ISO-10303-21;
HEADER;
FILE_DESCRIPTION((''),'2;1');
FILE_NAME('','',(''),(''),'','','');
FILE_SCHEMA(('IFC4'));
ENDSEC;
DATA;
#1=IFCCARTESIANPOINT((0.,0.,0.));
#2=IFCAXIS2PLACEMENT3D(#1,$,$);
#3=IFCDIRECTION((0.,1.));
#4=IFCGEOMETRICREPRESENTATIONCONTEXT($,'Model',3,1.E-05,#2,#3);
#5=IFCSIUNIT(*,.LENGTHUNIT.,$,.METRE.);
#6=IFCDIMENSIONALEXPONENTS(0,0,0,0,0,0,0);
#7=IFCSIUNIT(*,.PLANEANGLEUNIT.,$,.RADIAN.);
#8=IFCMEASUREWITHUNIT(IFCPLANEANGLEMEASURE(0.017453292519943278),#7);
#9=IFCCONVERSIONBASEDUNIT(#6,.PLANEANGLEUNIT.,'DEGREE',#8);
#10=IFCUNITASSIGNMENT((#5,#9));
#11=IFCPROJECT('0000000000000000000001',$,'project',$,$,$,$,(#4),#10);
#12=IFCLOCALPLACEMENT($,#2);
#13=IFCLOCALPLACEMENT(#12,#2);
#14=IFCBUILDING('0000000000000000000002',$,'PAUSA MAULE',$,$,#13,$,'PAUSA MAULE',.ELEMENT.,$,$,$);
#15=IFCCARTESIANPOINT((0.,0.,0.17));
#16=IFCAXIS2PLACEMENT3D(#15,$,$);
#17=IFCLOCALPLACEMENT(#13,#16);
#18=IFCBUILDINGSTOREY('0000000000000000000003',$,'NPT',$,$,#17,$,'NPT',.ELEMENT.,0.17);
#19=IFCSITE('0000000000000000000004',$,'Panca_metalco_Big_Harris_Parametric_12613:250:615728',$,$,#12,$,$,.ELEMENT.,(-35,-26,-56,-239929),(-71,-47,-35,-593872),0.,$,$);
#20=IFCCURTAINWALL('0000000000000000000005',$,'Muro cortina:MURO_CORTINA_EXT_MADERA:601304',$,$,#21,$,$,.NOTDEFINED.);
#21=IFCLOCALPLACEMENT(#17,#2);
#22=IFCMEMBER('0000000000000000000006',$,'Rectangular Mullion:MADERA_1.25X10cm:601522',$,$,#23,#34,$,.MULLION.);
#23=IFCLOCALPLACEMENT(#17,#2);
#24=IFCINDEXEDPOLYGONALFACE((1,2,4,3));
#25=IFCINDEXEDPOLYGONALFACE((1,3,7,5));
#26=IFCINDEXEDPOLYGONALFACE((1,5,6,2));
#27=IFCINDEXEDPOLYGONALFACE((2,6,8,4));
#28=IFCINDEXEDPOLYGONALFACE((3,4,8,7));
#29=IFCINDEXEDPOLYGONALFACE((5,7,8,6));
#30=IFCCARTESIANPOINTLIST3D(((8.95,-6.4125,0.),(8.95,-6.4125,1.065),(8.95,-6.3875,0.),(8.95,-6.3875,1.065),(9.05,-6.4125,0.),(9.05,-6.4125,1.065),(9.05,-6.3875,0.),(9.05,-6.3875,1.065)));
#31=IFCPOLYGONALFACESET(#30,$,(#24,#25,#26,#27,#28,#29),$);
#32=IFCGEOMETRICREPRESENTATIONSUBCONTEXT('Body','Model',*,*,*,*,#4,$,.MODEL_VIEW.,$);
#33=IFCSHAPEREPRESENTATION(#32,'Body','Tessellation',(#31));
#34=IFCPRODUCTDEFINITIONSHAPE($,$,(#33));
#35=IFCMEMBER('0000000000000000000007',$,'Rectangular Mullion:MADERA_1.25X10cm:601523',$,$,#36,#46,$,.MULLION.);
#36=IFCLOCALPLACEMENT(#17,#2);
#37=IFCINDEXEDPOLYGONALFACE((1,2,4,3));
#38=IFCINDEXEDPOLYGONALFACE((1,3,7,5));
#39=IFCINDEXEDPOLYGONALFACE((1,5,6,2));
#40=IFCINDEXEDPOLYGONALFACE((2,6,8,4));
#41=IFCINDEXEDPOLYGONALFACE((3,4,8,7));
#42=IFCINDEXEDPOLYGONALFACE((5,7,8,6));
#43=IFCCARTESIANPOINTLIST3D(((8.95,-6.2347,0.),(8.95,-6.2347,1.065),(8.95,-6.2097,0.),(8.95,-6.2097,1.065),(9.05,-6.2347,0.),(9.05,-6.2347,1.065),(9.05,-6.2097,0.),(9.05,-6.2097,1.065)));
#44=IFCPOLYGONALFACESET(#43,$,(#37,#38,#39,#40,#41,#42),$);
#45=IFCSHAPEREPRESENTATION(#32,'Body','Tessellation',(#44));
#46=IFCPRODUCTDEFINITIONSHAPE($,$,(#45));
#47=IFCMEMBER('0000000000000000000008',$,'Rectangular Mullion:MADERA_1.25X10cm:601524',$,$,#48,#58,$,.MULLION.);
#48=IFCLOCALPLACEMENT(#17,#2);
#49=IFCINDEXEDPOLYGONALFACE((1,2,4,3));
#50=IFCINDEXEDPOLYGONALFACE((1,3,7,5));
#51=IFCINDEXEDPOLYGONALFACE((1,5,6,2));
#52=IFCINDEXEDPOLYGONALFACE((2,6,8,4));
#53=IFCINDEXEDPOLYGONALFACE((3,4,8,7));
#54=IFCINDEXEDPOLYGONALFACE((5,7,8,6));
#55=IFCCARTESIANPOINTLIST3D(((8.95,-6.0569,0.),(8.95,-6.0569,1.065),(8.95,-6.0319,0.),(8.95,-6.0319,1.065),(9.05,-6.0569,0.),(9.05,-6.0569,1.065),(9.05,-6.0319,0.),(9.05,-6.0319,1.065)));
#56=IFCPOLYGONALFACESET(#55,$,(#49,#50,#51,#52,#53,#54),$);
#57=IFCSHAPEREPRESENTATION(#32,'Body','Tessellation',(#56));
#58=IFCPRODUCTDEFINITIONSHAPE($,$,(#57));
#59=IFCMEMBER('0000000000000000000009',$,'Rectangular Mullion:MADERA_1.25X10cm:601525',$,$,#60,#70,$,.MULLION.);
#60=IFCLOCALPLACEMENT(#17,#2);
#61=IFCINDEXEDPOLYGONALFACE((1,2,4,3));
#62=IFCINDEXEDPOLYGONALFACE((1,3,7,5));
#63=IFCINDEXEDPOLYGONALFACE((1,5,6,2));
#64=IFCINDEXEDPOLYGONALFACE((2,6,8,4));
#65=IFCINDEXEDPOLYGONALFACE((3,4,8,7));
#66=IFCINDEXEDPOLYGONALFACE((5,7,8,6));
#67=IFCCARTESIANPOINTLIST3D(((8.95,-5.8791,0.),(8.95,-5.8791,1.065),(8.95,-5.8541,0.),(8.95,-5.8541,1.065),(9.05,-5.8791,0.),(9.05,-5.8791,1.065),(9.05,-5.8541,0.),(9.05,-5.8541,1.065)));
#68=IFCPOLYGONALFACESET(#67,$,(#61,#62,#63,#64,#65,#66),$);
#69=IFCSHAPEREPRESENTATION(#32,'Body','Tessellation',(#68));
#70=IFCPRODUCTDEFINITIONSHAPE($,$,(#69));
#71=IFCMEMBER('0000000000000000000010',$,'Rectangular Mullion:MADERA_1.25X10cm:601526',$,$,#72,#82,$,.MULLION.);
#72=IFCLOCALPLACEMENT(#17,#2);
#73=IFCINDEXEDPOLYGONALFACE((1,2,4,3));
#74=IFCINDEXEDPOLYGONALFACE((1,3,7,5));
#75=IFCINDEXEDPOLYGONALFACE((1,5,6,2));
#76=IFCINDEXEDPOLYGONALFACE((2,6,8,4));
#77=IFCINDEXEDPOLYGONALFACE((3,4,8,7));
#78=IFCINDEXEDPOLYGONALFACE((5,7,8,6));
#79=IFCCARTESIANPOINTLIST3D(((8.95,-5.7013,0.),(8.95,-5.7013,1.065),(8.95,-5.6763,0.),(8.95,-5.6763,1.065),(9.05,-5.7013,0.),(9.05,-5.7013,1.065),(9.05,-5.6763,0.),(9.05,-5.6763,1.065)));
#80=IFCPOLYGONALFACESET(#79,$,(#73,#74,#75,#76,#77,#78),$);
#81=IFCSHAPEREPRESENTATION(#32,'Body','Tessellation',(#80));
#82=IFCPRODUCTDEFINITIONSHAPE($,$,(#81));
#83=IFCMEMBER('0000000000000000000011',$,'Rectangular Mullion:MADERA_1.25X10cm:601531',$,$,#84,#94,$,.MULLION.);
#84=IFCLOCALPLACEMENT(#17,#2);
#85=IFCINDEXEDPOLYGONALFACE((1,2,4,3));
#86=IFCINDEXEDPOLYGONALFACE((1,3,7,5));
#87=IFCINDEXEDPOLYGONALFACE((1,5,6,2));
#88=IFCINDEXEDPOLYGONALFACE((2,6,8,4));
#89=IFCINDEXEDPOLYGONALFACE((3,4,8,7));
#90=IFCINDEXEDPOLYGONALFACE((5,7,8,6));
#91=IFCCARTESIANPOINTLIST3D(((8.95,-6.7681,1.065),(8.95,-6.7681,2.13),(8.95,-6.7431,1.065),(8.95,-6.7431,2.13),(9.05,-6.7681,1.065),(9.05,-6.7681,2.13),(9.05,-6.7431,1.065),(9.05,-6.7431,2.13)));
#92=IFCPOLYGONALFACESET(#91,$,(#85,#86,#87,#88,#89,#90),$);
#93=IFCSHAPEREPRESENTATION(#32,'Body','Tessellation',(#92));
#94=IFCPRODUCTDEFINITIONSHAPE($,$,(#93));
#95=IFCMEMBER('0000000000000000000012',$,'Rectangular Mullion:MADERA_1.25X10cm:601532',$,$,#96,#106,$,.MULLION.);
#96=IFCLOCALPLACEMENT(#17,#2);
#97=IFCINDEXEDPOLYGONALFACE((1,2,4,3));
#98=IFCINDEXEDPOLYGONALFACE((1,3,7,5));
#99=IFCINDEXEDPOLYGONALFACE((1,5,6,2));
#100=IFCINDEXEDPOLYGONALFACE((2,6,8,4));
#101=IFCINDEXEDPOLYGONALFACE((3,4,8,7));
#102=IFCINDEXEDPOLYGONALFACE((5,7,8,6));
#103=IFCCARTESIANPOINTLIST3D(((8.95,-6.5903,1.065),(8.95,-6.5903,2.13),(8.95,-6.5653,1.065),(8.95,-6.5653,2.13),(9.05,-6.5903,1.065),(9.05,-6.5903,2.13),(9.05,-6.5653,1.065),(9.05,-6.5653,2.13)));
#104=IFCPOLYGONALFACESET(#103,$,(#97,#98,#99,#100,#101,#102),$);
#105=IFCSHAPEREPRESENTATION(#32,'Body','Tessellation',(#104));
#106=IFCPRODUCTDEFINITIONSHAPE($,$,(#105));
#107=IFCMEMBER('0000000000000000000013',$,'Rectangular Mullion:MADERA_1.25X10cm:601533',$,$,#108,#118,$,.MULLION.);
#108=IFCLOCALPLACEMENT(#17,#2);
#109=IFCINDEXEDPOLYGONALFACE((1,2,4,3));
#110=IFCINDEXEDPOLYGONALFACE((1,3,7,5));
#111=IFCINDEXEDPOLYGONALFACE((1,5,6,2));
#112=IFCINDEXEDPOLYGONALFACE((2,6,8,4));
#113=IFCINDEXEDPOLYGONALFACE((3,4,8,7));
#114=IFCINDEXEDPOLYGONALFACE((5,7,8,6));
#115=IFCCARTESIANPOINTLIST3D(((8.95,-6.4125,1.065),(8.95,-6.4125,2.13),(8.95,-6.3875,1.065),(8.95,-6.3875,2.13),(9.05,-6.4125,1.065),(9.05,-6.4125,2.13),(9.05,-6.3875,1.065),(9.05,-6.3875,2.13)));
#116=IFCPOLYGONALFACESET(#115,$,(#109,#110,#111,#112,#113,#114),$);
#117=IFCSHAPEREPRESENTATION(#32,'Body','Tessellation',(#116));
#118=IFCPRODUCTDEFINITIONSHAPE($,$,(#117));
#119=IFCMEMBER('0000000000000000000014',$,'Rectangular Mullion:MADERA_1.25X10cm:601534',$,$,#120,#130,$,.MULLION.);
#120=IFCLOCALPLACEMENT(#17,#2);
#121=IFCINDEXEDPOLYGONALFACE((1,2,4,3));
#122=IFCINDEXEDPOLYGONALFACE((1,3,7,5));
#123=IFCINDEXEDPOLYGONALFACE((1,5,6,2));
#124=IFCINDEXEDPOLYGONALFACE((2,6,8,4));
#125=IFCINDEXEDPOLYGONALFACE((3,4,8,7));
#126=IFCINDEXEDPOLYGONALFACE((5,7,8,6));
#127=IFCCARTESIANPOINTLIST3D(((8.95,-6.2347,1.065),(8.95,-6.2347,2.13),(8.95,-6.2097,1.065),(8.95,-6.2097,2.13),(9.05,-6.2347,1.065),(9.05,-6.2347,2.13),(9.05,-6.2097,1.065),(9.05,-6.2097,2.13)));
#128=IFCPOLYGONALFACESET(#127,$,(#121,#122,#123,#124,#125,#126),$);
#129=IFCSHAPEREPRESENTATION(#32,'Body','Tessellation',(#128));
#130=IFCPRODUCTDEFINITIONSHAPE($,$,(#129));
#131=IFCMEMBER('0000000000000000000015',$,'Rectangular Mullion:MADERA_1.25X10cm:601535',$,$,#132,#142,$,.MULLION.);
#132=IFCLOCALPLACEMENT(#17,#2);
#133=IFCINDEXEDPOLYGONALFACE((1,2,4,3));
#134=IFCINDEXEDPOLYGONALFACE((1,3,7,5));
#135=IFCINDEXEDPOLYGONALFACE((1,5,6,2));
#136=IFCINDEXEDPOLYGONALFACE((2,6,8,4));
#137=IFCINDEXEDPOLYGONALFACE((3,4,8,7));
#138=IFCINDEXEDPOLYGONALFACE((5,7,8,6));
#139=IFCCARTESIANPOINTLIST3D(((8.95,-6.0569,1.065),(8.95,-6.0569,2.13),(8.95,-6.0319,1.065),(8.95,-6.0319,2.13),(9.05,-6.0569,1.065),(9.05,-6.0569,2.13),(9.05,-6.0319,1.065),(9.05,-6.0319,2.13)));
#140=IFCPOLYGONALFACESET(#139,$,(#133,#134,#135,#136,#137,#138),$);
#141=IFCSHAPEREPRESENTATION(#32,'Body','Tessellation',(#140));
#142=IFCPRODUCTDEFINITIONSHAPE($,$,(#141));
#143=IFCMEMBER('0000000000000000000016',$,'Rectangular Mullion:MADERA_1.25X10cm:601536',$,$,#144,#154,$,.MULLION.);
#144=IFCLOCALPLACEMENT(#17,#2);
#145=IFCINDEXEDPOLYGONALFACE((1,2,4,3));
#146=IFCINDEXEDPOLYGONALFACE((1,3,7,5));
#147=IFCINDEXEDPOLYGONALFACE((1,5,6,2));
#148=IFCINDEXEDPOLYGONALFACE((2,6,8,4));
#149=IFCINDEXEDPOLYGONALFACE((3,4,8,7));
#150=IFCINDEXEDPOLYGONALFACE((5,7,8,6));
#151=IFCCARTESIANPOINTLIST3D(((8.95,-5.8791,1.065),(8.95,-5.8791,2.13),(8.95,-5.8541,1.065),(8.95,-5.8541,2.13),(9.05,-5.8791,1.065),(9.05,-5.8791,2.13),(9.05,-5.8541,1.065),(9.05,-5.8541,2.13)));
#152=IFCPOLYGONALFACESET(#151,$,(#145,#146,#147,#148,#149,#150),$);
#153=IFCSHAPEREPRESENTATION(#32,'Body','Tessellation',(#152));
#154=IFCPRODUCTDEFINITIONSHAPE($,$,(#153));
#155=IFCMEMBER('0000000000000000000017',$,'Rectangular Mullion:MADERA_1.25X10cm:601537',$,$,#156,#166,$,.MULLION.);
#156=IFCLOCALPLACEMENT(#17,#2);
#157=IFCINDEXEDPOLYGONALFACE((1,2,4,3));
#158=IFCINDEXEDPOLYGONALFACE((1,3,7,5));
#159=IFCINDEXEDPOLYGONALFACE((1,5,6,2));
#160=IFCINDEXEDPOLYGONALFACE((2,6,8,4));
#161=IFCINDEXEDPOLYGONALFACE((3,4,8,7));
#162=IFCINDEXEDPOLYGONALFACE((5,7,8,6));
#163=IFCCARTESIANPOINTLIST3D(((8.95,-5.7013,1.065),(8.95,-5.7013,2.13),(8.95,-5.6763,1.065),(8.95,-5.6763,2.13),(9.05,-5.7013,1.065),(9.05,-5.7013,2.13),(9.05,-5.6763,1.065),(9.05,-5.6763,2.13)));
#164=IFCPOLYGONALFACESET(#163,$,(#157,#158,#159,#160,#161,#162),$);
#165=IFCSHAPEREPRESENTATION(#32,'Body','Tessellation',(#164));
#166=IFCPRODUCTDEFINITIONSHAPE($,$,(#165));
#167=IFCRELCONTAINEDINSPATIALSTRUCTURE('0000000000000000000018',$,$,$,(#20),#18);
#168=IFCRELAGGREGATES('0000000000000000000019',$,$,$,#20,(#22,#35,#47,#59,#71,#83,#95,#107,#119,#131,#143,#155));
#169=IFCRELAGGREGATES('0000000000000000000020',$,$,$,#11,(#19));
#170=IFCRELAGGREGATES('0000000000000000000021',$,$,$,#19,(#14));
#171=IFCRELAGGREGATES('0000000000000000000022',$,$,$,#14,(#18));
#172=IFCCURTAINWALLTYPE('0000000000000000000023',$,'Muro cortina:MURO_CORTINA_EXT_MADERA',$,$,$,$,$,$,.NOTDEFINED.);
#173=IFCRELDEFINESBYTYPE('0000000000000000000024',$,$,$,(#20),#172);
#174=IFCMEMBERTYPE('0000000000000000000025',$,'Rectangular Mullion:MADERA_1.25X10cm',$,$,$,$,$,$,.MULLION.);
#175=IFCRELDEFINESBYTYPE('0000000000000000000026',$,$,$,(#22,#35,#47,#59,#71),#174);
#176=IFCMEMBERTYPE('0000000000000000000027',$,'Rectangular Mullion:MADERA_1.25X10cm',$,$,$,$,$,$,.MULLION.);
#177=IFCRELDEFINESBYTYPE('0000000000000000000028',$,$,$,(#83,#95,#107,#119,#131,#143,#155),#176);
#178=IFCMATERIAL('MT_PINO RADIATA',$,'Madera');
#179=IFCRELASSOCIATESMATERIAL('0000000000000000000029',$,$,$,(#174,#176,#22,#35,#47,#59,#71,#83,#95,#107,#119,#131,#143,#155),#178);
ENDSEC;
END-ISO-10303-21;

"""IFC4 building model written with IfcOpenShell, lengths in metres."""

from ifc_helpers import new_model, entity, si_unit, converted_unit, direction, frame, frame_2d, origin, place, context, subcontext, project, spatial, rectangle, extrude, source, transform, mapped, material, material_profile, profile_set, profile_usage, type_object, type_shapes, element, aggregate, save


model = new_model("IFC4")

# Units and contexts
model_context = context("Model", 3, precision=1e-05, world=origin(), true_north=direction((0.0, 1.0)))
body_context = subcontext(model_context, "Body", "Model", "MODEL_VIEW")
ifc_project = project(units=[si_unit("LENGTHUNIT", "METRE"), converted_unit("PLANEANGLEUNIT", "DEGREE", entity("IfcPlaneAngleMeasure", 0.017453292519943278), si_unit("PLANEANGLEUNIT", "RADIAN"), dimensions=[0, 0, 0, 0, 0, 0, 0])], contexts=[model_context])

# Site, building, storey
site_placement = place(None, origin())
site = spatial("IfcSite", under=ifc_project, at=site_placement, Name="Panca_metalco_Big_Harris_Parametric_12613:250:615728", CompositionType="ELEMENT", RefLatitude=(-35, -26, -56, -239929), RefLongitude=(-71, -47, -35, -593872), RefElevation=0.0)
building_placement = place(site_placement, origin())
building = spatial("IfcBuilding", under=site, at=building_placement, Name="PAUSA MAULE", LongName="PAUSA MAULE", CompositionType="ELEMENT")
storey_placement = place(building_placement, frame((0.0, 0.0, 0.17)))
storey = spatial("IfcBuildingStorey", under=building, at=storey_placement, Name="NPT", LongName="NPT", CompositionType="ELEMENT", Elevation=0.17)

# Curtain wall, members
curtain_wall_type = type_object("IfcCurtainWallType", Name="Muro cortina:MURO_CORTINA_EXT_MADERA", PredefinedType="NOTDEFINED")
curtain_wall_placement = place(storey_placement, frame((0.0, 0.0, -0.17)))
curtain_wall = element("IfcCurtainWall", 1, at=curtain_wall_placement, inside=storey, type_object=curtain_wall_type, Name="Muro cortina:MURO_CORTINA_EXT_MADERA:601304", PredefinedType="NOTDEFINED")
ifc_material = material(Name="MT_PINO RADIATA", Category="Madera")
ifc_material_profile = material_profile(ifc_material, rectangle(XDim=0.025, YDim=0.1, at=frame_2d((0.0, 0.0), x_axis=(1.0, 0.0))), Name="MADERA_1.25X10cm")
ifc_profile_set = profile_set([ifc_material_profile], Name="MADERA_1.25X10cm")
ifc_profile_usage = profile_usage(ifc_profile_set)
member_type_1 = type_object("IfcMemberType", Name="Rectangular Mullion:MADERA_1.25X10cm", PredefinedType="MULLION", material=ifc_profile_set)
shared_shape_1 = source(origin(), body_context, "Body", "SweptSolid", [
    extrude(rectangle(XDim=0.025, YDim=0.1, at=frame_2d((0.0, 0.0), x_axis=(1.0, 0.0))), frame((0.0, 0.0, -1.065), z_axis=(0.0, 0.0, 1.0), x_axis=(-1.0, 0.0, 0.0)), (0.0, 0.0, 1.0), 1.065),
])
type_shapes(member_type_1, [shared_shape_1])
member_1_placement = place(curtain_wall_placement, frame((9.0, -6.4, 0.17), z_axis=(0.0, 0.0, -1.0), x_axis=(0.0, 1.0, 0.0)))
member_1 = element("IfcMember", 2, at=member_1_placement, type_object=member_type_1, material=ifc_profile_usage, Name="Rectangular Mullion:MADERA_1.25X10cm:601522", PredefinedType="MULLION", context=body_context, shape_type="MappedRepresentation", body=[
    mapped(shared_shape_1, transform((0.0, 0.0, 0.0), scale=1.0)),
])
member_2_placement = place(curtain_wall_placement, frame((9.0, -6.2222, 0.17), z_axis=(0.0, 0.0, -1.0), x_axis=(0.0, 1.0, 0.0)))
member_2 = element("IfcMember", 3, at=member_2_placement, type_object=member_type_1, material=ifc_profile_usage, Name="Rectangular Mullion:MADERA_1.25X10cm:601523", PredefinedType="MULLION", context=body_context, shape_type="MappedRepresentation", body=[
    mapped(shared_shape_1, transform((0.0, 0.0, 0.0), scale=1.0)),
])
member_3_placement = place(curtain_wall_placement, frame((9.0, -6.0444, 0.17), z_axis=(0.0, 0.0, -1.0), x_axis=(0.0, 1.0, 0.0)))
member_3 = element("IfcMember", 4, at=member_3_placement, type_object=member_type_1, material=ifc_profile_usage, Name="Rectangular Mullion:MADERA_1.25X10cm:601524", PredefinedType="MULLION", context=body_context, shape_type="MappedRepresentation", body=[
    mapped(shared_shape_1, transform((0.0, 0.0, 0.0), scale=1.0)),
])
member_4_placement = place(curtain_wall_placement, frame((9.0, -5.8666, 0.17), z_axis=(0.0, 0.0, -1.0), x_axis=(0.0, 1.0, 0.0)))
member_4 = element("IfcMember", 5, at=member_4_placement, type_object=member_type_1, material=ifc_profile_usage, Name="Rectangular Mullion:MADERA_1.25X10cm:601525", PredefinedType="MULLION", context=body_context, shape_type="MappedRepresentation", body=[
    mapped(shared_shape_1, transform((0.0, 0.0, 0.0), scale=1.0)),
])
member_5_placement = place(curtain_wall_placement, frame((9.0, -5.6888, 0.17), z_axis=(0.0, 0.0, -1.0), x_axis=(0.0, 1.0, 0.0)))
member_5 = element("IfcMember", 6, at=member_5_placement, type_object=member_type_1, material=ifc_profile_usage, Name="Rectangular Mullion:MADERA_1.25X10cm:601526", PredefinedType="MULLION", context=body_context, shape_type="MappedRepresentation", body=[
    mapped(shared_shape_1, transform((0.0, 0.0, 0.0), scale=1.0)),
])
member_type_2 = type_object("IfcMemberType", Name="Rectangular Mullion:MADERA_1.25X10cm", PredefinedType="MULLION", material=ifc_profile_set)
shared_shape_2 = source(origin(), body_context, "Body", "SweptSolid", [
    extrude(rectangle(XDim=0.025, YDim=0.1, at=frame_2d((0.0, 0.0), x_axis=(1.0, 0.0))), frame((0.0, 0.0, -1.065), z_axis=(0.0, 0.0, 1.0), x_axis=(-1.0, 0.0, 0.0)), (0.0, 0.0, 1.0), 1.065),
])
type_shapes(member_type_2, [shared_shape_2])
member_6_placement = place(curtain_wall_placement, frame((9.0, -6.7556, 1.235), z_axis=(0.0, 0.0, -1.0), x_axis=(0.0, 1.0, 0.0)))
member_6 = element("IfcMember", 7, at=member_6_placement, type_object=member_type_2, material=ifc_profile_usage, Name="Rectangular Mullion:MADERA_1.25X10cm:601531", PredefinedType="MULLION", context=body_context, shape_type="MappedRepresentation", body=[
    mapped(shared_shape_2, transform((0.0, 0.0, 0.0), scale=1.0)),
])
member_7_placement = place(curtain_wall_placement, frame((9.0, -6.5778, 1.235), z_axis=(0.0, 0.0, -1.0), x_axis=(0.0, 1.0, 0.0)))
member_7 = element("IfcMember", 8, at=member_7_placement, type_object=member_type_2, material=ifc_profile_usage, Name="Rectangular Mullion:MADERA_1.25X10cm:601532", PredefinedType="MULLION", context=body_context, shape_type="MappedRepresentation", body=[
    mapped(shared_shape_2, transform((0.0, 0.0, 0.0), scale=1.0)),
])
member_8_placement = place(curtain_wall_placement, frame((9.0, -6.4, 1.235), z_axis=(0.0, 0.0, -1.0), x_axis=(0.0, 1.0, 0.0)))
member_8 = element("IfcMember", 9, at=member_8_placement, type_object=member_type_2, material=ifc_profile_usage, Name="Rectangular Mullion:MADERA_1.25X10cm:601533", PredefinedType="MULLION", context=body_context, shape_type="MappedRepresentation", body=[
    mapped(shared_shape_2, transform((0.0, 0.0, 0.0), scale=1.0)),
])
member_9_placement = place(curtain_wall_placement, frame((9.0, -6.2222, 1.235), z_axis=(0.0, 0.0, -1.0), x_axis=(0.0, 1.0, 0.0)))
member_9 = element("IfcMember", 10, at=member_9_placement, type_object=member_type_2, material=ifc_profile_usage, Name="Rectangular Mullion:MADERA_1.25X10cm:601534", PredefinedType="MULLION", context=body_context, shape_type="MappedRepresentation", body=[
    mapped(shared_shape_2, transform((0.0, 0.0, 0.0), scale=1.0)),
])
member_10_placement = place(curtain_wall_placement, frame((9.0, -6.0444, 1.235), z_axis=(0.0, 0.0, -1.0), x_axis=(0.0, 1.0, 0.0)))
member_10 = element("IfcMember", 11, at=member_10_placement, type_object=member_type_2, material=ifc_profile_usage, Name="Rectangular Mullion:MADERA_1.25X10cm:601535", PredefinedType="MULLION", context=body_context, shape_type="MappedRepresentation", body=[
    mapped(shared_shape_2, transform((0.0, 0.0, 0.0), scale=1.0)),
])
member_11_placement = place(curtain_wall_placement, frame((9.0, -5.8666, 1.235), z_axis=(0.0, 0.0, -1.0), x_axis=(0.0, 1.0, 0.0)))
member_11 = element("IfcMember", 12, at=member_11_placement, type_object=member_type_2, material=ifc_profile_usage, Name="Rectangular Mullion:MADERA_1.25X10cm:601536", PredefinedType="MULLION", context=body_context, shape_type="MappedRepresentation", body=[
    mapped(shared_shape_2, transform((0.0, 0.0, 0.0), scale=1.0)),
])
member_12_placement = place(curtain_wall_placement, frame((9.0, -5.6888, 1.235), z_axis=(0.0, 0.0, -1.0), x_axis=(0.0, 1.0, 0.0)))
member_12 = element("IfcMember", 13, at=member_12_placement, type_object=member_type_2, material=ifc_profile_usage, Name="Rectangular Mullion:MADERA_1.25X10cm:601537", PredefinedType="MULLION", context=body_context, shape_type="MappedRepresentation", body=[
    mapped(shared_shape_2, transform((0.0, 0.0, 0.0), scale=1.0)),
])
aggregate(curtain_wall, [member_1, member_2, member_3, member_4, member_5, member_6, member_7, member_8, member_9, member_10, member_11, member_12])

save(model, "model.ifc")
